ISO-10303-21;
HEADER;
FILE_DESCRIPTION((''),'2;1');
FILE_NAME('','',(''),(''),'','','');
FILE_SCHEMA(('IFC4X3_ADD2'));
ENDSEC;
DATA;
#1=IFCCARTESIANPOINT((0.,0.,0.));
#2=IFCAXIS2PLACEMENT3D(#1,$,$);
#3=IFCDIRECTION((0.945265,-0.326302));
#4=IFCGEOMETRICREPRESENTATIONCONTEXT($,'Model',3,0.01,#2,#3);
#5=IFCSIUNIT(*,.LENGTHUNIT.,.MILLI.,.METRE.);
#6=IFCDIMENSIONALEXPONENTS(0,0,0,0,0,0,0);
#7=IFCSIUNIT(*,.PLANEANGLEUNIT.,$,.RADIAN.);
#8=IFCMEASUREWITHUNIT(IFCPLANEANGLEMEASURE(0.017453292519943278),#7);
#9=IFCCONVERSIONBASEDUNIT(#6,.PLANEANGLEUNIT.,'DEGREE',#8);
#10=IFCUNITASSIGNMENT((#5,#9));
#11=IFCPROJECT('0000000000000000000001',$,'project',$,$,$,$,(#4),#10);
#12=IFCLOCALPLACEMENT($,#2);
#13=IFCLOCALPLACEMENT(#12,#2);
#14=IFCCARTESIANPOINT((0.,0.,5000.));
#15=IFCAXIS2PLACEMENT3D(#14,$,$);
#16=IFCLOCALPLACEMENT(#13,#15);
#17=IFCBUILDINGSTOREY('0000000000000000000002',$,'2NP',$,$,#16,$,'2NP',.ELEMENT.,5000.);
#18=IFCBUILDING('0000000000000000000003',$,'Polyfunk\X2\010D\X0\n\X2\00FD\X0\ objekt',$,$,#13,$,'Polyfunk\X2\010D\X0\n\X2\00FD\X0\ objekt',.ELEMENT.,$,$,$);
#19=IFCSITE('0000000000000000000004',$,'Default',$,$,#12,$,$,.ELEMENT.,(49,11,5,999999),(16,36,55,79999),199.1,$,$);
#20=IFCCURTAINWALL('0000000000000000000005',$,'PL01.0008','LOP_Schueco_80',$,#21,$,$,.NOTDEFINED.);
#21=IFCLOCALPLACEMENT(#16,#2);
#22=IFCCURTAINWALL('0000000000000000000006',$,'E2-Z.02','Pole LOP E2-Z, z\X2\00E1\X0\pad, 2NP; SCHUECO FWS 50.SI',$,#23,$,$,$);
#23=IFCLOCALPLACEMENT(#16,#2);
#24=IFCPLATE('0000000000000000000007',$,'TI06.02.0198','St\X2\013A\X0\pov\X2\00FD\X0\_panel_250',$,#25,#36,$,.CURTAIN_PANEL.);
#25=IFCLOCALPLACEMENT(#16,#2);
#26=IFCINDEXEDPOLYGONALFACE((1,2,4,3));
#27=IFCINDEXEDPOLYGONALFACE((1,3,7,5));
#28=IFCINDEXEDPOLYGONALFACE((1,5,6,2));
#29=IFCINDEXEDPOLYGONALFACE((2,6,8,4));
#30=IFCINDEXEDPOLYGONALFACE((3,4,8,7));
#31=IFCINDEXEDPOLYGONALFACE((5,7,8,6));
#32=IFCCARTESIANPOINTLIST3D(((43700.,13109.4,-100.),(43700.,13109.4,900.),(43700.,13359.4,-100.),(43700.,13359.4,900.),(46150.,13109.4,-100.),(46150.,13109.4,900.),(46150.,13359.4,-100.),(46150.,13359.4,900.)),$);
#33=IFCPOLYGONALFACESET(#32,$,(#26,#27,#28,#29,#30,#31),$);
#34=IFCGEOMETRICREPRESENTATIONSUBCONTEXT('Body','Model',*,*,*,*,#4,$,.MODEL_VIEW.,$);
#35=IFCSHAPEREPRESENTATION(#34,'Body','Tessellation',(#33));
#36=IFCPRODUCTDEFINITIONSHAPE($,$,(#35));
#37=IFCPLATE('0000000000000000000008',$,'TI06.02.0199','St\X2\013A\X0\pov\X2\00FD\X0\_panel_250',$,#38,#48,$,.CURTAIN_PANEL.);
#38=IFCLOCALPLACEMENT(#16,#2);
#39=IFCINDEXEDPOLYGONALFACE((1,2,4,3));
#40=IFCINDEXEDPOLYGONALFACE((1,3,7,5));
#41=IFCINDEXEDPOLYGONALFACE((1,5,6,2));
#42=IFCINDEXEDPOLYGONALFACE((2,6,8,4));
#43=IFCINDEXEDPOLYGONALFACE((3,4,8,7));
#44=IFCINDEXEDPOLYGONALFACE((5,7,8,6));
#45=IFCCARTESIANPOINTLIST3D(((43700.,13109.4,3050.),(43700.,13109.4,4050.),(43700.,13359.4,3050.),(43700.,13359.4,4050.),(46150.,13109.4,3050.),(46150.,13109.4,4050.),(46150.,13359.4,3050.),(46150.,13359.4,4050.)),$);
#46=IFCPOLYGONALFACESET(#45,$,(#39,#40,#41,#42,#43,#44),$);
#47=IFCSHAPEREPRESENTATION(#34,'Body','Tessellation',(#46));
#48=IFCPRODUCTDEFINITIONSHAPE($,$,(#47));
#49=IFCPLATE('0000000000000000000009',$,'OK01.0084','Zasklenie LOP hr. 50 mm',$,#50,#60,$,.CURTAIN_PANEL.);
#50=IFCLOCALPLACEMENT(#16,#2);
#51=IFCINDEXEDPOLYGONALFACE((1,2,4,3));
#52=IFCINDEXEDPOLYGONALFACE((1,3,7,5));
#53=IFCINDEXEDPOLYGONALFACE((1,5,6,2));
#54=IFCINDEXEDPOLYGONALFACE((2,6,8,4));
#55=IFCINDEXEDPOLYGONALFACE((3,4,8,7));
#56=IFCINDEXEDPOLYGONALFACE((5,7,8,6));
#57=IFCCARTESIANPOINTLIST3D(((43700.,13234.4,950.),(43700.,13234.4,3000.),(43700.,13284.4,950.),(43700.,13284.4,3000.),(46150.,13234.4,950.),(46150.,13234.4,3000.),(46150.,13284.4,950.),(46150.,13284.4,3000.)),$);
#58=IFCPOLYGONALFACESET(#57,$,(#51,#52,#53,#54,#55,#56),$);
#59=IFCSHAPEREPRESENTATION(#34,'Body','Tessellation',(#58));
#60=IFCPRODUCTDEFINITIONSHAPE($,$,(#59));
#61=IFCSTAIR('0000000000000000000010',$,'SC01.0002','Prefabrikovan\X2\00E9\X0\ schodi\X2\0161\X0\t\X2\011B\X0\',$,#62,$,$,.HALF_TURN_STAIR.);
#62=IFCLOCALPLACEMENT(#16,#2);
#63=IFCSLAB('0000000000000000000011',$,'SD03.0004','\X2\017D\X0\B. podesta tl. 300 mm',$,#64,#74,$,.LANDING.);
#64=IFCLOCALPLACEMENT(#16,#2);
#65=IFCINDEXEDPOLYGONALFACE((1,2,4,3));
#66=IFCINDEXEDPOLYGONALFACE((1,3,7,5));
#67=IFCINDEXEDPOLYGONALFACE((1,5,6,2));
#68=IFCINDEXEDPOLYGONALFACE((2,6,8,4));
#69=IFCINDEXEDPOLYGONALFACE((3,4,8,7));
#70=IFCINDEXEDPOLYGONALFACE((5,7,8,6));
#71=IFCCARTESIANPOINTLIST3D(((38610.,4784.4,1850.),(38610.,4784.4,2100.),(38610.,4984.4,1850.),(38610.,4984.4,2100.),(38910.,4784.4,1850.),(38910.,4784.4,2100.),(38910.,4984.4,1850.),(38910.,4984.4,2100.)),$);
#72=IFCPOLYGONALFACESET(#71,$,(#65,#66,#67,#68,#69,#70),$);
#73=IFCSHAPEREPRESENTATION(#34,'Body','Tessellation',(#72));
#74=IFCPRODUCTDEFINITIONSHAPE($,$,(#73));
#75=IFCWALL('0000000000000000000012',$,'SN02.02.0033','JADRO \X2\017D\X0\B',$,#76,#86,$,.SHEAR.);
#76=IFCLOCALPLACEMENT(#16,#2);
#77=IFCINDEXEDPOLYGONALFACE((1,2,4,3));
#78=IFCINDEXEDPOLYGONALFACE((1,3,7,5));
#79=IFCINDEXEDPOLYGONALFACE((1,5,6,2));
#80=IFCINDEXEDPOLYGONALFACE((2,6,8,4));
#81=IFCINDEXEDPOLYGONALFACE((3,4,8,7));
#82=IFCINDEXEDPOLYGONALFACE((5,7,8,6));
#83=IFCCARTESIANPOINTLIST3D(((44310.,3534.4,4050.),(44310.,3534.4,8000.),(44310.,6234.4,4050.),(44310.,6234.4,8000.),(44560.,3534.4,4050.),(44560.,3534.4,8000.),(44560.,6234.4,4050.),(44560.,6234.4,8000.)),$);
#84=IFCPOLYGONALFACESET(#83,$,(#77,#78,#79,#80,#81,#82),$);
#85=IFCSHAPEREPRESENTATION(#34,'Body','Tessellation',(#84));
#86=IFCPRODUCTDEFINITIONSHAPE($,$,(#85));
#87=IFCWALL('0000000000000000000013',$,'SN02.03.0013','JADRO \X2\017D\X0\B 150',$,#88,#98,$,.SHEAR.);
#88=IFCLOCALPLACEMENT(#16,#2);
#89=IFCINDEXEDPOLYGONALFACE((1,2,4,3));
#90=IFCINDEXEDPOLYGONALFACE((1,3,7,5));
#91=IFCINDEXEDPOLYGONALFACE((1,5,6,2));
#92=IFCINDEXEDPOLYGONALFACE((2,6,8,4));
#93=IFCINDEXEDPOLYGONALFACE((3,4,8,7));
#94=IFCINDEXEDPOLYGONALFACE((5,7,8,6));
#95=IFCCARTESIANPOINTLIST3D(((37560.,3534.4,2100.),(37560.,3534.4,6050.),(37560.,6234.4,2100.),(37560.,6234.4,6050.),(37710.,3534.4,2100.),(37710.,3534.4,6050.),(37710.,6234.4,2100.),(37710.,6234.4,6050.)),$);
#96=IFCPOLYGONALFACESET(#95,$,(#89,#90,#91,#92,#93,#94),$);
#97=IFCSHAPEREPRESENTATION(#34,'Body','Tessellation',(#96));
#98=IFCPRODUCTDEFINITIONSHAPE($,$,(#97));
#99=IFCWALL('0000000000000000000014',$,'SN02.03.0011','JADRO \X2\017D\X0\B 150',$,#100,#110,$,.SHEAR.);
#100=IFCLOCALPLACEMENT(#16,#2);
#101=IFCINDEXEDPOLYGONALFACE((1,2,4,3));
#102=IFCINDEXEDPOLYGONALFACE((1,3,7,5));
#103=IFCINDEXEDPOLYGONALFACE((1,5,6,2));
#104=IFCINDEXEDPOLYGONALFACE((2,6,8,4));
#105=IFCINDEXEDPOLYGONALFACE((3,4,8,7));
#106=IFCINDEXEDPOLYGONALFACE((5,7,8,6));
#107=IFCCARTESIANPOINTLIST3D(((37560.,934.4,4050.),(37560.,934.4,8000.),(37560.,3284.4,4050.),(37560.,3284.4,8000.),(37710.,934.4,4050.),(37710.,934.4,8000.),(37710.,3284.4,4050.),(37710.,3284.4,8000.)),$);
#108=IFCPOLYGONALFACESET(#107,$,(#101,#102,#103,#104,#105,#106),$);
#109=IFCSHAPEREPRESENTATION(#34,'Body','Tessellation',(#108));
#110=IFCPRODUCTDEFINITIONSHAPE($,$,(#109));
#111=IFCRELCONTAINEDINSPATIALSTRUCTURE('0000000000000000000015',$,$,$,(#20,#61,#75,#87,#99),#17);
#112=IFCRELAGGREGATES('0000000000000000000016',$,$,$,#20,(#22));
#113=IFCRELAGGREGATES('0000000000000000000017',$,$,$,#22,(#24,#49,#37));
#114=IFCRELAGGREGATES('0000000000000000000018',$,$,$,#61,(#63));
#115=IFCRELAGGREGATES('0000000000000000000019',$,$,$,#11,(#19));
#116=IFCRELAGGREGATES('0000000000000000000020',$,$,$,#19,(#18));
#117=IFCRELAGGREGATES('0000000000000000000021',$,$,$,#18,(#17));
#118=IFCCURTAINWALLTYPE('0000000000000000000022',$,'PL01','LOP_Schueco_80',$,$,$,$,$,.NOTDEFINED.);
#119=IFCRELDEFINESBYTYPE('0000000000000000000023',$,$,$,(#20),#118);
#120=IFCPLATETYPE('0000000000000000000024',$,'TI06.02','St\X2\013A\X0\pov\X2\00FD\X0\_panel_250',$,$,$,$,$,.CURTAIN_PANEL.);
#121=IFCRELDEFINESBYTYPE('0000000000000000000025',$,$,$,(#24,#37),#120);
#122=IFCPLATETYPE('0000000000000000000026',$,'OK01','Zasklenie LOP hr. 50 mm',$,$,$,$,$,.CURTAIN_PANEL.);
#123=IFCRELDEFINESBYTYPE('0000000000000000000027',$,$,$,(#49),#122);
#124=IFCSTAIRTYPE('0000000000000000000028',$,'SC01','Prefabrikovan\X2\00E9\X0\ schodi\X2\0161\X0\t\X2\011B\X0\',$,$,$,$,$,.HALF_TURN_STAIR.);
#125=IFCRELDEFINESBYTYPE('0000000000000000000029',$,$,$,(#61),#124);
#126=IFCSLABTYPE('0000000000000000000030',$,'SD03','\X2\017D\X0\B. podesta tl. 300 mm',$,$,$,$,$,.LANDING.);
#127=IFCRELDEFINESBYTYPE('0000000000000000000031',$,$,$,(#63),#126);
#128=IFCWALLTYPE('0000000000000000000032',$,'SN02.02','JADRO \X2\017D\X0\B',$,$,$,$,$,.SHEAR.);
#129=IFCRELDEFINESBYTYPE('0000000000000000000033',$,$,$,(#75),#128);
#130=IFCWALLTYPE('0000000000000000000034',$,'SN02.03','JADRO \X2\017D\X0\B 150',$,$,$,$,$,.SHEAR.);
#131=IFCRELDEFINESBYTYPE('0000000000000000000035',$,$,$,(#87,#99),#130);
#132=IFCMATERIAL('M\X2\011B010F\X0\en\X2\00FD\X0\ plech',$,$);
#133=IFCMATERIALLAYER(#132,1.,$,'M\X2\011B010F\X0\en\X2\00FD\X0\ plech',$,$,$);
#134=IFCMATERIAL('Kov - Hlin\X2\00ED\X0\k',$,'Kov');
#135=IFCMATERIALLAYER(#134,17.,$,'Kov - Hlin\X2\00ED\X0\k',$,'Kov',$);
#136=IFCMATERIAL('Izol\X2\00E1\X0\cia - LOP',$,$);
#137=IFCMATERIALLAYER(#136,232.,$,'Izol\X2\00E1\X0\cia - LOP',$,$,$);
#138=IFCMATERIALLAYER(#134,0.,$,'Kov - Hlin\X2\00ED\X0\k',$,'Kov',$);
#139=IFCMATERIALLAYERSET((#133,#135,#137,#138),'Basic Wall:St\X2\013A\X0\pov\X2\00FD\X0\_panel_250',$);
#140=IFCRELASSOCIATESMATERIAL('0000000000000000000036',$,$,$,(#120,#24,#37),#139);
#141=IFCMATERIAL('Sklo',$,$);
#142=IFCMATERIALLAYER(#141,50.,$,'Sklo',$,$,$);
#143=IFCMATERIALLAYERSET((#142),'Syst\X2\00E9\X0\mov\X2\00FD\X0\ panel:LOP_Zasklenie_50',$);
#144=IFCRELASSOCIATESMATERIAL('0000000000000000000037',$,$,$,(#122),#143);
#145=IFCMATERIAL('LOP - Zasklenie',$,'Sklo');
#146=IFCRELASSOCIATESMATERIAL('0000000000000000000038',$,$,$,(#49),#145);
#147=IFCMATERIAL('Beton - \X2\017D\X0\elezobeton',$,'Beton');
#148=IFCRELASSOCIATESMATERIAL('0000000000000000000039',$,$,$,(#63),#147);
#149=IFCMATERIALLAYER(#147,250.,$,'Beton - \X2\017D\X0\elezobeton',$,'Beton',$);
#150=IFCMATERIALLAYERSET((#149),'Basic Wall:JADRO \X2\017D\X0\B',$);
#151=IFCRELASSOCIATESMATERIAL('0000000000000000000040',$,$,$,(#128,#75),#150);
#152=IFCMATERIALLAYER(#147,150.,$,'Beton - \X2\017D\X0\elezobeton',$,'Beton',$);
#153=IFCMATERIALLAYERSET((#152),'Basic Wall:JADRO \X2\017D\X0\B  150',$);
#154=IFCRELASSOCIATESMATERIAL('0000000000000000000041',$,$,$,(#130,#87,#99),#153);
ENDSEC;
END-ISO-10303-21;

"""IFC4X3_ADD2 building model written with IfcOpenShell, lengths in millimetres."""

from ifc_helpers import new_model, entity, si_unit, converted_unit, direction, frame, frame_2d, origin, origin_2d_with_axis, place, context, subcontext, project, spatial, polyline, rectangle, extrude, clip, bounded_halfspace, source, transform, mapped, material, layer, layer_set, layer_usage, type_object, type_shapes, element, aggregate, save


model = new_model("IFC4X3_ADD2")

# Units and contexts
model_context = context("Model", 3, precision=0.01, world=origin(), true_north=direction((0.945265, -0.326302)))
body_context = subcontext(model_context, "Body", "Model", "MODEL_VIEW")
ifc_project = project(units=[si_unit("LENGTHUNIT", "METRE", prefix="MILLI"), converted_unit("PLANEANGLEUNIT", "DEGREE", entity("IfcPlaneAngleMeasure", 0.017453292519943278), si_unit("PLANEANGLEUNIT", "RADIAN"), dimensions=[0, 0, 0, 0, 0, 0, 0])], contexts=[model_context])

# Site, building, storey
site_placement = place(None, origin())
site = spatial("IfcSite", under=ifc_project, at=site_placement, Name="Default", CompositionType="ELEMENT", RefLatitude=(49, 11, 5, 999999), RefLongitude=(16, 36, 55, 79999), RefElevation=199.1)
building_placement = place(site_placement, origin())
building = spatial("IfcBuilding", under=site, at=building_placement, Name="Polyfunkčný objekt", LongName="Polyfunkčný objekt", CompositionType="ELEMENT")
storey_placement = place(building_placement, frame((0.0, 0.0, 5000.0)))
storey = spatial("IfcBuildingStorey", under=building, at=storey_placement, Name="2NP", LongName="2NP", CompositionType="ELEMENT", Elevation=5000.0)

# Curtain walls, plates
curtain_wall_type = type_object("IfcCurtainWallType", Name="PL01", Description="LOP_Schueco_80", PredefinedType="NOTDEFINED")
curtain_wall_1_placement = place(storey_placement, frame((0.0, 0.0, -5000.0)))
curtain_wall_1 = element("IfcCurtainWall", 1, at=curtain_wall_1_placement, inside=storey, type_object=curtain_wall_type, Name="PL01.0008", Description="LOP_Schueco_80", PredefinedType="NOTDEFINED")
curtain_wall_2 = element("IfcCurtainWall", 2, Name="E2-Z.02", Description="Pole LOP E2-Z, západ, 2NP; SCHUECO FWS 50.SI")
aggregate(curtain_wall_1, [curtain_wall_2])
ifc_material_1 = material(Name="Měďený plech")
ifc_layer_1 = layer(ifc_material_1, 1.0, Name="Měďený plech")
ifc_material_2 = material(Name="Kov - Hliník", Category="Kov")
ifc_layer_2 = layer(ifc_material_2, 17.0, Name="Kov - Hliník", Category="Kov")
ifc_material_3 = material(Name="Izolácia - LOP")
ifc_layer_3 = layer(ifc_material_3, 232.0, Name="Izolácia - LOP")
ifc_layer_4 = layer(ifc_material_2, 0.0, Name="Kov - Hliník", Category="Kov")
ifc_layer_set_1 = layer_set([ifc_layer_1, ifc_layer_2, ifc_layer_3, ifc_layer_4], Name="Basic Wall:Stĺpový_panel_250")
ifc_layer_usage_1 = layer_usage(ifc_layer_set_1, "AXIS2", "NEGATIVE", 125.0)
plate_type_1 = type_object("IfcPlateType", Name="TI06.02", Description="Stĺpový_panel_250", PredefinedType="CURTAIN_PANEL", material=ifc_layer_set_1)
plate_1_placement = place(storey_placement, frame((43700.0, 13234.4, -100.0)))
plate_1 = element("IfcPlate", 3, at=plate_1_placement, type_object=plate_type_1, material=ifc_layer_usage_1, Name="TI06.02.0198", Description="Stĺpový_panel_250", PredefinedType="CURTAIN_PANEL", context=body_context, shape_type="SweptSolid", body=[
    extrude(rectangle(XDim=250.0, YDim=2450.0, at=frame_2d((0.0, 0.0), x_axis=(1.0, 0.0))), frame((1225.0, 0.0, 0.0), z_axis=(0.0, 0.0, 1.0), x_axis=(0.0, 1.0, 0.0)), (0.0, 0.0, 1.0), 1000.0),
])
ifc_layer_usage_2 = layer_usage(ifc_layer_set_1, "AXIS2", "NEGATIVE", 125.0)
plate_2_placement = place(storey_placement, frame((43700.0, 13234.4, 3050.0)))
plate_2 = element("IfcPlate", 4, at=plate_2_placement, type_object=plate_type_1, material=ifc_layer_usage_2, Name="TI06.02.0199", Description="Stĺpový_panel_250", PredefinedType="CURTAIN_PANEL", context=body_context, shape_type="SweptSolid", body=[
    extrude(rectangle(XDim=250.0, YDim=2450.0, at=frame_2d((0.0, 0.0), x_axis=(1.0, 0.0))), frame((1225.0, 0.0, 0.0), z_axis=(0.0, 0.0, 1.0), x_axis=(0.0, 1.0, 0.0)), (0.0, 0.0, 1.0), 1000.0),
])
ifc_material_4 = material(Name="LOP - Zasklenie", Category="Sklo")
ifc_material_5 = material(Name="Sklo")
ifc_layer_5 = layer(ifc_material_5, 50.0, Name="Sklo")
ifc_layer_set_2 = layer_set([ifc_layer_5], Name="Systémový panel:LOP_Zasklenie_50")
plate_type_2 = type_object("IfcPlateType", Name="OK01", Description="Zasklenie LOP hr. 50 mm", PredefinedType="CURTAIN_PANEL", material=ifc_layer_set_2)
shared_shape_1 = source(origin(), body_context, "Body", "SweptSolid", [
    extrude(rectangle(XDim=50.0, YDim=2450.0, at=origin_2d_with_axis()), frame((0.0, 25.0, 0.0), z_axis=(0.0, 0.0, 1.0), x_axis=(0.0, 1.0, 0.0)), (0.0, 0.0, 1.0), 2050.0),
])
type_shapes(plate_type_2, [shared_shape_1])
plate_3_placement = place(curtain_wall_1_placement, frame((44925.0, 13234.4, 5950.0)))
plate_3 = element("IfcPlate", 5, at=plate_3_placement, type_object=plate_type_2, material=ifc_material_4, Name="OK01.0084", Description="Zasklenie LOP hr. 50 mm", PredefinedType="CURTAIN_PANEL", context=body_context, shape_type="MappedRepresentation", body=[
    mapped(shared_shape_1, transform((0.0, 0.0, 0.0), scale=1.0)),
])
aggregate(curtain_wall_2, [plate_1, plate_3, plate_2])

# Stair, slab
stair_type = type_object("IfcStairType", Name="SC01", Description="Prefabrikované schodiště", PredefinedType="HALF_TURN_STAIR")
stair_placement = place(storey_placement, origin())
stair = element("IfcStair", 6, at=stair_placement, inside=storey, type_object=stair_type, Name="SC01.0002", Description="Prefabrikované schodiště", PredefinedType="HALF_TURN_STAIR")
ifc_material_6 = material(Name="Beton - Železobeton", Category="Beton")
slab_type = type_object("IfcSlabType", Name="SD03", Description="ŽB. podesta tl. 300 mm", PredefinedType="LANDING")
slab_placement = place(stair_placement, frame((38610.0, 4784.4, 0.0)))
slab = element("IfcSlab", 7, at=slab_placement, type_object=slab_type, material=ifc_material_6, Name="SD03.0004", Description="ŽB. podesta tl. 300 mm", PredefinedType="LANDING", context=body_context, shape_type="SweptSolid", body=[
    extrude(rectangle(XDim=200.0, YDim=300.0, at=frame_2d((0.0, 0.0), x_axis=(1.0, 0.0))), frame((150.0, 100.0, 1850.0), z_axis=(0.0, 0.0, 1.0), x_axis=(0.0, 1.0, 0.0)), (0.0, 0.0, 1.0), 250.0),
])
aggregate(stair, [slab])

# Walls
ifc_layer_6 = layer(ifc_material_6, 250.0, Name="Beton - Železobeton", Category="Beton")
ifc_layer_set_3 = layer_set([ifc_layer_6], Name="Basic Wall:JADRO ŽB")
wall_type_1 = type_object("IfcWallType", Name="SN02.02", Description="JADRO ŽB", PredefinedType="SHEAR", material=ifc_layer_set_3)
wall_1_placement = place(storey_placement, frame((44435.0, 6234.4, 4050.0), z_axis=(0.0, 0.0, 1.0), x_axis=(0.0, -1.0, 0.0)))
element("IfcWall", 8, at=wall_1_placement, inside=storey, type_object=wall_type_1, material=ifc_layer_set_3, Name="SN02.02.0033", Description="JADRO ŽB", PredefinedType="SHEAR", context=body_context, shape_type="Clipping", body=[
    clip(clip(extrude(rectangle(XDim=2700.0, YDim=250.0, at=frame_2d((1350.0, 0.0), x_axis=(-1.0, 0.0))), origin(), (0.0, 0.0, 1.0), 3950.0), bounded_halfspace(frame((2700.0, -125.0, 0.0), z_axis=(0.0, 0.0, 1.0), x_axis=(0.0, -1.0, 0.0)), True, frame((2700.0, -125.0, 0.0)), polyline([(0.0, 0.0), (0.0, 250.0), (-2700.0, 250.0), (-2700.0, 0.0), (0.0, 0.0)]))), bounded_halfspace(frame((0.0, -125.0, 3950.0), z_axis=(0.0, 0.0, -1.0), x_axis=(0.0, 1.0, 0.0)), True, frame((0.0, -125.0, 3950.0)), polyline([(0.0, 0.0), (2700.0, 0.0), (2700.0, 250.0), (0.0, 250.0), (0.0, 0.0)]))),
])
ifc_layer_7 = layer(ifc_material_6, 150.0, Name="Beton - Železobeton", Category="Beton")
ifc_layer_set_4 = layer_set([ifc_layer_7], Name="Basic Wall:JADRO ŽB  150")
wall_type_2 = type_object("IfcWallType", Name="SN02.03", Description="JADRO ŽB 150", PredefinedType="SHEAR", material=ifc_layer_set_4)
wall_2_placement = place(storey_placement, frame((37635.0, 6234.4, 2100.0), z_axis=(0.0, 0.0, 1.0), x_axis=(0.0, -1.0, 0.0)))
element("IfcWall", 9, at=wall_2_placement, inside=storey, type_object=wall_type_2, material=ifc_layer_set_4, Name="SN02.03.0013", Description="JADRO ŽB 150", PredefinedType="SHEAR", context=body_context, shape_type="SweptSolid", body=[
    extrude(rectangle(XDim=2700.0, YDim=150.0, at=frame_2d((1350.0, 0.0), x_axis=(-1.0, 0.0))), origin(), (0.0, 0.0, 1.0), 3950.0),
])
wall_3_placement = place(storey_placement, frame((37635.0, 3284.4, 4050.0), z_axis=(0.0, 0.0, 1.0), x_axis=(0.0, -1.0, 0.0)))
element("IfcWall", 10, at=wall_3_placement, inside=storey, type_object=wall_type_2, material=ifc_layer_set_4, Name="SN02.03.0011", Description="JADRO ŽB 150", PredefinedType="SHEAR", context=body_context, shape_type="SweptSolid", body=[
    extrude(rectangle(XDim=2350.0, YDim=150.0, at=frame_2d((1175.0, 0.0), x_axis=(-1.0, 0.0))), origin(), (0.0, 0.0, 1.0), 3950.0),
])

save(model, "model.ifc")
